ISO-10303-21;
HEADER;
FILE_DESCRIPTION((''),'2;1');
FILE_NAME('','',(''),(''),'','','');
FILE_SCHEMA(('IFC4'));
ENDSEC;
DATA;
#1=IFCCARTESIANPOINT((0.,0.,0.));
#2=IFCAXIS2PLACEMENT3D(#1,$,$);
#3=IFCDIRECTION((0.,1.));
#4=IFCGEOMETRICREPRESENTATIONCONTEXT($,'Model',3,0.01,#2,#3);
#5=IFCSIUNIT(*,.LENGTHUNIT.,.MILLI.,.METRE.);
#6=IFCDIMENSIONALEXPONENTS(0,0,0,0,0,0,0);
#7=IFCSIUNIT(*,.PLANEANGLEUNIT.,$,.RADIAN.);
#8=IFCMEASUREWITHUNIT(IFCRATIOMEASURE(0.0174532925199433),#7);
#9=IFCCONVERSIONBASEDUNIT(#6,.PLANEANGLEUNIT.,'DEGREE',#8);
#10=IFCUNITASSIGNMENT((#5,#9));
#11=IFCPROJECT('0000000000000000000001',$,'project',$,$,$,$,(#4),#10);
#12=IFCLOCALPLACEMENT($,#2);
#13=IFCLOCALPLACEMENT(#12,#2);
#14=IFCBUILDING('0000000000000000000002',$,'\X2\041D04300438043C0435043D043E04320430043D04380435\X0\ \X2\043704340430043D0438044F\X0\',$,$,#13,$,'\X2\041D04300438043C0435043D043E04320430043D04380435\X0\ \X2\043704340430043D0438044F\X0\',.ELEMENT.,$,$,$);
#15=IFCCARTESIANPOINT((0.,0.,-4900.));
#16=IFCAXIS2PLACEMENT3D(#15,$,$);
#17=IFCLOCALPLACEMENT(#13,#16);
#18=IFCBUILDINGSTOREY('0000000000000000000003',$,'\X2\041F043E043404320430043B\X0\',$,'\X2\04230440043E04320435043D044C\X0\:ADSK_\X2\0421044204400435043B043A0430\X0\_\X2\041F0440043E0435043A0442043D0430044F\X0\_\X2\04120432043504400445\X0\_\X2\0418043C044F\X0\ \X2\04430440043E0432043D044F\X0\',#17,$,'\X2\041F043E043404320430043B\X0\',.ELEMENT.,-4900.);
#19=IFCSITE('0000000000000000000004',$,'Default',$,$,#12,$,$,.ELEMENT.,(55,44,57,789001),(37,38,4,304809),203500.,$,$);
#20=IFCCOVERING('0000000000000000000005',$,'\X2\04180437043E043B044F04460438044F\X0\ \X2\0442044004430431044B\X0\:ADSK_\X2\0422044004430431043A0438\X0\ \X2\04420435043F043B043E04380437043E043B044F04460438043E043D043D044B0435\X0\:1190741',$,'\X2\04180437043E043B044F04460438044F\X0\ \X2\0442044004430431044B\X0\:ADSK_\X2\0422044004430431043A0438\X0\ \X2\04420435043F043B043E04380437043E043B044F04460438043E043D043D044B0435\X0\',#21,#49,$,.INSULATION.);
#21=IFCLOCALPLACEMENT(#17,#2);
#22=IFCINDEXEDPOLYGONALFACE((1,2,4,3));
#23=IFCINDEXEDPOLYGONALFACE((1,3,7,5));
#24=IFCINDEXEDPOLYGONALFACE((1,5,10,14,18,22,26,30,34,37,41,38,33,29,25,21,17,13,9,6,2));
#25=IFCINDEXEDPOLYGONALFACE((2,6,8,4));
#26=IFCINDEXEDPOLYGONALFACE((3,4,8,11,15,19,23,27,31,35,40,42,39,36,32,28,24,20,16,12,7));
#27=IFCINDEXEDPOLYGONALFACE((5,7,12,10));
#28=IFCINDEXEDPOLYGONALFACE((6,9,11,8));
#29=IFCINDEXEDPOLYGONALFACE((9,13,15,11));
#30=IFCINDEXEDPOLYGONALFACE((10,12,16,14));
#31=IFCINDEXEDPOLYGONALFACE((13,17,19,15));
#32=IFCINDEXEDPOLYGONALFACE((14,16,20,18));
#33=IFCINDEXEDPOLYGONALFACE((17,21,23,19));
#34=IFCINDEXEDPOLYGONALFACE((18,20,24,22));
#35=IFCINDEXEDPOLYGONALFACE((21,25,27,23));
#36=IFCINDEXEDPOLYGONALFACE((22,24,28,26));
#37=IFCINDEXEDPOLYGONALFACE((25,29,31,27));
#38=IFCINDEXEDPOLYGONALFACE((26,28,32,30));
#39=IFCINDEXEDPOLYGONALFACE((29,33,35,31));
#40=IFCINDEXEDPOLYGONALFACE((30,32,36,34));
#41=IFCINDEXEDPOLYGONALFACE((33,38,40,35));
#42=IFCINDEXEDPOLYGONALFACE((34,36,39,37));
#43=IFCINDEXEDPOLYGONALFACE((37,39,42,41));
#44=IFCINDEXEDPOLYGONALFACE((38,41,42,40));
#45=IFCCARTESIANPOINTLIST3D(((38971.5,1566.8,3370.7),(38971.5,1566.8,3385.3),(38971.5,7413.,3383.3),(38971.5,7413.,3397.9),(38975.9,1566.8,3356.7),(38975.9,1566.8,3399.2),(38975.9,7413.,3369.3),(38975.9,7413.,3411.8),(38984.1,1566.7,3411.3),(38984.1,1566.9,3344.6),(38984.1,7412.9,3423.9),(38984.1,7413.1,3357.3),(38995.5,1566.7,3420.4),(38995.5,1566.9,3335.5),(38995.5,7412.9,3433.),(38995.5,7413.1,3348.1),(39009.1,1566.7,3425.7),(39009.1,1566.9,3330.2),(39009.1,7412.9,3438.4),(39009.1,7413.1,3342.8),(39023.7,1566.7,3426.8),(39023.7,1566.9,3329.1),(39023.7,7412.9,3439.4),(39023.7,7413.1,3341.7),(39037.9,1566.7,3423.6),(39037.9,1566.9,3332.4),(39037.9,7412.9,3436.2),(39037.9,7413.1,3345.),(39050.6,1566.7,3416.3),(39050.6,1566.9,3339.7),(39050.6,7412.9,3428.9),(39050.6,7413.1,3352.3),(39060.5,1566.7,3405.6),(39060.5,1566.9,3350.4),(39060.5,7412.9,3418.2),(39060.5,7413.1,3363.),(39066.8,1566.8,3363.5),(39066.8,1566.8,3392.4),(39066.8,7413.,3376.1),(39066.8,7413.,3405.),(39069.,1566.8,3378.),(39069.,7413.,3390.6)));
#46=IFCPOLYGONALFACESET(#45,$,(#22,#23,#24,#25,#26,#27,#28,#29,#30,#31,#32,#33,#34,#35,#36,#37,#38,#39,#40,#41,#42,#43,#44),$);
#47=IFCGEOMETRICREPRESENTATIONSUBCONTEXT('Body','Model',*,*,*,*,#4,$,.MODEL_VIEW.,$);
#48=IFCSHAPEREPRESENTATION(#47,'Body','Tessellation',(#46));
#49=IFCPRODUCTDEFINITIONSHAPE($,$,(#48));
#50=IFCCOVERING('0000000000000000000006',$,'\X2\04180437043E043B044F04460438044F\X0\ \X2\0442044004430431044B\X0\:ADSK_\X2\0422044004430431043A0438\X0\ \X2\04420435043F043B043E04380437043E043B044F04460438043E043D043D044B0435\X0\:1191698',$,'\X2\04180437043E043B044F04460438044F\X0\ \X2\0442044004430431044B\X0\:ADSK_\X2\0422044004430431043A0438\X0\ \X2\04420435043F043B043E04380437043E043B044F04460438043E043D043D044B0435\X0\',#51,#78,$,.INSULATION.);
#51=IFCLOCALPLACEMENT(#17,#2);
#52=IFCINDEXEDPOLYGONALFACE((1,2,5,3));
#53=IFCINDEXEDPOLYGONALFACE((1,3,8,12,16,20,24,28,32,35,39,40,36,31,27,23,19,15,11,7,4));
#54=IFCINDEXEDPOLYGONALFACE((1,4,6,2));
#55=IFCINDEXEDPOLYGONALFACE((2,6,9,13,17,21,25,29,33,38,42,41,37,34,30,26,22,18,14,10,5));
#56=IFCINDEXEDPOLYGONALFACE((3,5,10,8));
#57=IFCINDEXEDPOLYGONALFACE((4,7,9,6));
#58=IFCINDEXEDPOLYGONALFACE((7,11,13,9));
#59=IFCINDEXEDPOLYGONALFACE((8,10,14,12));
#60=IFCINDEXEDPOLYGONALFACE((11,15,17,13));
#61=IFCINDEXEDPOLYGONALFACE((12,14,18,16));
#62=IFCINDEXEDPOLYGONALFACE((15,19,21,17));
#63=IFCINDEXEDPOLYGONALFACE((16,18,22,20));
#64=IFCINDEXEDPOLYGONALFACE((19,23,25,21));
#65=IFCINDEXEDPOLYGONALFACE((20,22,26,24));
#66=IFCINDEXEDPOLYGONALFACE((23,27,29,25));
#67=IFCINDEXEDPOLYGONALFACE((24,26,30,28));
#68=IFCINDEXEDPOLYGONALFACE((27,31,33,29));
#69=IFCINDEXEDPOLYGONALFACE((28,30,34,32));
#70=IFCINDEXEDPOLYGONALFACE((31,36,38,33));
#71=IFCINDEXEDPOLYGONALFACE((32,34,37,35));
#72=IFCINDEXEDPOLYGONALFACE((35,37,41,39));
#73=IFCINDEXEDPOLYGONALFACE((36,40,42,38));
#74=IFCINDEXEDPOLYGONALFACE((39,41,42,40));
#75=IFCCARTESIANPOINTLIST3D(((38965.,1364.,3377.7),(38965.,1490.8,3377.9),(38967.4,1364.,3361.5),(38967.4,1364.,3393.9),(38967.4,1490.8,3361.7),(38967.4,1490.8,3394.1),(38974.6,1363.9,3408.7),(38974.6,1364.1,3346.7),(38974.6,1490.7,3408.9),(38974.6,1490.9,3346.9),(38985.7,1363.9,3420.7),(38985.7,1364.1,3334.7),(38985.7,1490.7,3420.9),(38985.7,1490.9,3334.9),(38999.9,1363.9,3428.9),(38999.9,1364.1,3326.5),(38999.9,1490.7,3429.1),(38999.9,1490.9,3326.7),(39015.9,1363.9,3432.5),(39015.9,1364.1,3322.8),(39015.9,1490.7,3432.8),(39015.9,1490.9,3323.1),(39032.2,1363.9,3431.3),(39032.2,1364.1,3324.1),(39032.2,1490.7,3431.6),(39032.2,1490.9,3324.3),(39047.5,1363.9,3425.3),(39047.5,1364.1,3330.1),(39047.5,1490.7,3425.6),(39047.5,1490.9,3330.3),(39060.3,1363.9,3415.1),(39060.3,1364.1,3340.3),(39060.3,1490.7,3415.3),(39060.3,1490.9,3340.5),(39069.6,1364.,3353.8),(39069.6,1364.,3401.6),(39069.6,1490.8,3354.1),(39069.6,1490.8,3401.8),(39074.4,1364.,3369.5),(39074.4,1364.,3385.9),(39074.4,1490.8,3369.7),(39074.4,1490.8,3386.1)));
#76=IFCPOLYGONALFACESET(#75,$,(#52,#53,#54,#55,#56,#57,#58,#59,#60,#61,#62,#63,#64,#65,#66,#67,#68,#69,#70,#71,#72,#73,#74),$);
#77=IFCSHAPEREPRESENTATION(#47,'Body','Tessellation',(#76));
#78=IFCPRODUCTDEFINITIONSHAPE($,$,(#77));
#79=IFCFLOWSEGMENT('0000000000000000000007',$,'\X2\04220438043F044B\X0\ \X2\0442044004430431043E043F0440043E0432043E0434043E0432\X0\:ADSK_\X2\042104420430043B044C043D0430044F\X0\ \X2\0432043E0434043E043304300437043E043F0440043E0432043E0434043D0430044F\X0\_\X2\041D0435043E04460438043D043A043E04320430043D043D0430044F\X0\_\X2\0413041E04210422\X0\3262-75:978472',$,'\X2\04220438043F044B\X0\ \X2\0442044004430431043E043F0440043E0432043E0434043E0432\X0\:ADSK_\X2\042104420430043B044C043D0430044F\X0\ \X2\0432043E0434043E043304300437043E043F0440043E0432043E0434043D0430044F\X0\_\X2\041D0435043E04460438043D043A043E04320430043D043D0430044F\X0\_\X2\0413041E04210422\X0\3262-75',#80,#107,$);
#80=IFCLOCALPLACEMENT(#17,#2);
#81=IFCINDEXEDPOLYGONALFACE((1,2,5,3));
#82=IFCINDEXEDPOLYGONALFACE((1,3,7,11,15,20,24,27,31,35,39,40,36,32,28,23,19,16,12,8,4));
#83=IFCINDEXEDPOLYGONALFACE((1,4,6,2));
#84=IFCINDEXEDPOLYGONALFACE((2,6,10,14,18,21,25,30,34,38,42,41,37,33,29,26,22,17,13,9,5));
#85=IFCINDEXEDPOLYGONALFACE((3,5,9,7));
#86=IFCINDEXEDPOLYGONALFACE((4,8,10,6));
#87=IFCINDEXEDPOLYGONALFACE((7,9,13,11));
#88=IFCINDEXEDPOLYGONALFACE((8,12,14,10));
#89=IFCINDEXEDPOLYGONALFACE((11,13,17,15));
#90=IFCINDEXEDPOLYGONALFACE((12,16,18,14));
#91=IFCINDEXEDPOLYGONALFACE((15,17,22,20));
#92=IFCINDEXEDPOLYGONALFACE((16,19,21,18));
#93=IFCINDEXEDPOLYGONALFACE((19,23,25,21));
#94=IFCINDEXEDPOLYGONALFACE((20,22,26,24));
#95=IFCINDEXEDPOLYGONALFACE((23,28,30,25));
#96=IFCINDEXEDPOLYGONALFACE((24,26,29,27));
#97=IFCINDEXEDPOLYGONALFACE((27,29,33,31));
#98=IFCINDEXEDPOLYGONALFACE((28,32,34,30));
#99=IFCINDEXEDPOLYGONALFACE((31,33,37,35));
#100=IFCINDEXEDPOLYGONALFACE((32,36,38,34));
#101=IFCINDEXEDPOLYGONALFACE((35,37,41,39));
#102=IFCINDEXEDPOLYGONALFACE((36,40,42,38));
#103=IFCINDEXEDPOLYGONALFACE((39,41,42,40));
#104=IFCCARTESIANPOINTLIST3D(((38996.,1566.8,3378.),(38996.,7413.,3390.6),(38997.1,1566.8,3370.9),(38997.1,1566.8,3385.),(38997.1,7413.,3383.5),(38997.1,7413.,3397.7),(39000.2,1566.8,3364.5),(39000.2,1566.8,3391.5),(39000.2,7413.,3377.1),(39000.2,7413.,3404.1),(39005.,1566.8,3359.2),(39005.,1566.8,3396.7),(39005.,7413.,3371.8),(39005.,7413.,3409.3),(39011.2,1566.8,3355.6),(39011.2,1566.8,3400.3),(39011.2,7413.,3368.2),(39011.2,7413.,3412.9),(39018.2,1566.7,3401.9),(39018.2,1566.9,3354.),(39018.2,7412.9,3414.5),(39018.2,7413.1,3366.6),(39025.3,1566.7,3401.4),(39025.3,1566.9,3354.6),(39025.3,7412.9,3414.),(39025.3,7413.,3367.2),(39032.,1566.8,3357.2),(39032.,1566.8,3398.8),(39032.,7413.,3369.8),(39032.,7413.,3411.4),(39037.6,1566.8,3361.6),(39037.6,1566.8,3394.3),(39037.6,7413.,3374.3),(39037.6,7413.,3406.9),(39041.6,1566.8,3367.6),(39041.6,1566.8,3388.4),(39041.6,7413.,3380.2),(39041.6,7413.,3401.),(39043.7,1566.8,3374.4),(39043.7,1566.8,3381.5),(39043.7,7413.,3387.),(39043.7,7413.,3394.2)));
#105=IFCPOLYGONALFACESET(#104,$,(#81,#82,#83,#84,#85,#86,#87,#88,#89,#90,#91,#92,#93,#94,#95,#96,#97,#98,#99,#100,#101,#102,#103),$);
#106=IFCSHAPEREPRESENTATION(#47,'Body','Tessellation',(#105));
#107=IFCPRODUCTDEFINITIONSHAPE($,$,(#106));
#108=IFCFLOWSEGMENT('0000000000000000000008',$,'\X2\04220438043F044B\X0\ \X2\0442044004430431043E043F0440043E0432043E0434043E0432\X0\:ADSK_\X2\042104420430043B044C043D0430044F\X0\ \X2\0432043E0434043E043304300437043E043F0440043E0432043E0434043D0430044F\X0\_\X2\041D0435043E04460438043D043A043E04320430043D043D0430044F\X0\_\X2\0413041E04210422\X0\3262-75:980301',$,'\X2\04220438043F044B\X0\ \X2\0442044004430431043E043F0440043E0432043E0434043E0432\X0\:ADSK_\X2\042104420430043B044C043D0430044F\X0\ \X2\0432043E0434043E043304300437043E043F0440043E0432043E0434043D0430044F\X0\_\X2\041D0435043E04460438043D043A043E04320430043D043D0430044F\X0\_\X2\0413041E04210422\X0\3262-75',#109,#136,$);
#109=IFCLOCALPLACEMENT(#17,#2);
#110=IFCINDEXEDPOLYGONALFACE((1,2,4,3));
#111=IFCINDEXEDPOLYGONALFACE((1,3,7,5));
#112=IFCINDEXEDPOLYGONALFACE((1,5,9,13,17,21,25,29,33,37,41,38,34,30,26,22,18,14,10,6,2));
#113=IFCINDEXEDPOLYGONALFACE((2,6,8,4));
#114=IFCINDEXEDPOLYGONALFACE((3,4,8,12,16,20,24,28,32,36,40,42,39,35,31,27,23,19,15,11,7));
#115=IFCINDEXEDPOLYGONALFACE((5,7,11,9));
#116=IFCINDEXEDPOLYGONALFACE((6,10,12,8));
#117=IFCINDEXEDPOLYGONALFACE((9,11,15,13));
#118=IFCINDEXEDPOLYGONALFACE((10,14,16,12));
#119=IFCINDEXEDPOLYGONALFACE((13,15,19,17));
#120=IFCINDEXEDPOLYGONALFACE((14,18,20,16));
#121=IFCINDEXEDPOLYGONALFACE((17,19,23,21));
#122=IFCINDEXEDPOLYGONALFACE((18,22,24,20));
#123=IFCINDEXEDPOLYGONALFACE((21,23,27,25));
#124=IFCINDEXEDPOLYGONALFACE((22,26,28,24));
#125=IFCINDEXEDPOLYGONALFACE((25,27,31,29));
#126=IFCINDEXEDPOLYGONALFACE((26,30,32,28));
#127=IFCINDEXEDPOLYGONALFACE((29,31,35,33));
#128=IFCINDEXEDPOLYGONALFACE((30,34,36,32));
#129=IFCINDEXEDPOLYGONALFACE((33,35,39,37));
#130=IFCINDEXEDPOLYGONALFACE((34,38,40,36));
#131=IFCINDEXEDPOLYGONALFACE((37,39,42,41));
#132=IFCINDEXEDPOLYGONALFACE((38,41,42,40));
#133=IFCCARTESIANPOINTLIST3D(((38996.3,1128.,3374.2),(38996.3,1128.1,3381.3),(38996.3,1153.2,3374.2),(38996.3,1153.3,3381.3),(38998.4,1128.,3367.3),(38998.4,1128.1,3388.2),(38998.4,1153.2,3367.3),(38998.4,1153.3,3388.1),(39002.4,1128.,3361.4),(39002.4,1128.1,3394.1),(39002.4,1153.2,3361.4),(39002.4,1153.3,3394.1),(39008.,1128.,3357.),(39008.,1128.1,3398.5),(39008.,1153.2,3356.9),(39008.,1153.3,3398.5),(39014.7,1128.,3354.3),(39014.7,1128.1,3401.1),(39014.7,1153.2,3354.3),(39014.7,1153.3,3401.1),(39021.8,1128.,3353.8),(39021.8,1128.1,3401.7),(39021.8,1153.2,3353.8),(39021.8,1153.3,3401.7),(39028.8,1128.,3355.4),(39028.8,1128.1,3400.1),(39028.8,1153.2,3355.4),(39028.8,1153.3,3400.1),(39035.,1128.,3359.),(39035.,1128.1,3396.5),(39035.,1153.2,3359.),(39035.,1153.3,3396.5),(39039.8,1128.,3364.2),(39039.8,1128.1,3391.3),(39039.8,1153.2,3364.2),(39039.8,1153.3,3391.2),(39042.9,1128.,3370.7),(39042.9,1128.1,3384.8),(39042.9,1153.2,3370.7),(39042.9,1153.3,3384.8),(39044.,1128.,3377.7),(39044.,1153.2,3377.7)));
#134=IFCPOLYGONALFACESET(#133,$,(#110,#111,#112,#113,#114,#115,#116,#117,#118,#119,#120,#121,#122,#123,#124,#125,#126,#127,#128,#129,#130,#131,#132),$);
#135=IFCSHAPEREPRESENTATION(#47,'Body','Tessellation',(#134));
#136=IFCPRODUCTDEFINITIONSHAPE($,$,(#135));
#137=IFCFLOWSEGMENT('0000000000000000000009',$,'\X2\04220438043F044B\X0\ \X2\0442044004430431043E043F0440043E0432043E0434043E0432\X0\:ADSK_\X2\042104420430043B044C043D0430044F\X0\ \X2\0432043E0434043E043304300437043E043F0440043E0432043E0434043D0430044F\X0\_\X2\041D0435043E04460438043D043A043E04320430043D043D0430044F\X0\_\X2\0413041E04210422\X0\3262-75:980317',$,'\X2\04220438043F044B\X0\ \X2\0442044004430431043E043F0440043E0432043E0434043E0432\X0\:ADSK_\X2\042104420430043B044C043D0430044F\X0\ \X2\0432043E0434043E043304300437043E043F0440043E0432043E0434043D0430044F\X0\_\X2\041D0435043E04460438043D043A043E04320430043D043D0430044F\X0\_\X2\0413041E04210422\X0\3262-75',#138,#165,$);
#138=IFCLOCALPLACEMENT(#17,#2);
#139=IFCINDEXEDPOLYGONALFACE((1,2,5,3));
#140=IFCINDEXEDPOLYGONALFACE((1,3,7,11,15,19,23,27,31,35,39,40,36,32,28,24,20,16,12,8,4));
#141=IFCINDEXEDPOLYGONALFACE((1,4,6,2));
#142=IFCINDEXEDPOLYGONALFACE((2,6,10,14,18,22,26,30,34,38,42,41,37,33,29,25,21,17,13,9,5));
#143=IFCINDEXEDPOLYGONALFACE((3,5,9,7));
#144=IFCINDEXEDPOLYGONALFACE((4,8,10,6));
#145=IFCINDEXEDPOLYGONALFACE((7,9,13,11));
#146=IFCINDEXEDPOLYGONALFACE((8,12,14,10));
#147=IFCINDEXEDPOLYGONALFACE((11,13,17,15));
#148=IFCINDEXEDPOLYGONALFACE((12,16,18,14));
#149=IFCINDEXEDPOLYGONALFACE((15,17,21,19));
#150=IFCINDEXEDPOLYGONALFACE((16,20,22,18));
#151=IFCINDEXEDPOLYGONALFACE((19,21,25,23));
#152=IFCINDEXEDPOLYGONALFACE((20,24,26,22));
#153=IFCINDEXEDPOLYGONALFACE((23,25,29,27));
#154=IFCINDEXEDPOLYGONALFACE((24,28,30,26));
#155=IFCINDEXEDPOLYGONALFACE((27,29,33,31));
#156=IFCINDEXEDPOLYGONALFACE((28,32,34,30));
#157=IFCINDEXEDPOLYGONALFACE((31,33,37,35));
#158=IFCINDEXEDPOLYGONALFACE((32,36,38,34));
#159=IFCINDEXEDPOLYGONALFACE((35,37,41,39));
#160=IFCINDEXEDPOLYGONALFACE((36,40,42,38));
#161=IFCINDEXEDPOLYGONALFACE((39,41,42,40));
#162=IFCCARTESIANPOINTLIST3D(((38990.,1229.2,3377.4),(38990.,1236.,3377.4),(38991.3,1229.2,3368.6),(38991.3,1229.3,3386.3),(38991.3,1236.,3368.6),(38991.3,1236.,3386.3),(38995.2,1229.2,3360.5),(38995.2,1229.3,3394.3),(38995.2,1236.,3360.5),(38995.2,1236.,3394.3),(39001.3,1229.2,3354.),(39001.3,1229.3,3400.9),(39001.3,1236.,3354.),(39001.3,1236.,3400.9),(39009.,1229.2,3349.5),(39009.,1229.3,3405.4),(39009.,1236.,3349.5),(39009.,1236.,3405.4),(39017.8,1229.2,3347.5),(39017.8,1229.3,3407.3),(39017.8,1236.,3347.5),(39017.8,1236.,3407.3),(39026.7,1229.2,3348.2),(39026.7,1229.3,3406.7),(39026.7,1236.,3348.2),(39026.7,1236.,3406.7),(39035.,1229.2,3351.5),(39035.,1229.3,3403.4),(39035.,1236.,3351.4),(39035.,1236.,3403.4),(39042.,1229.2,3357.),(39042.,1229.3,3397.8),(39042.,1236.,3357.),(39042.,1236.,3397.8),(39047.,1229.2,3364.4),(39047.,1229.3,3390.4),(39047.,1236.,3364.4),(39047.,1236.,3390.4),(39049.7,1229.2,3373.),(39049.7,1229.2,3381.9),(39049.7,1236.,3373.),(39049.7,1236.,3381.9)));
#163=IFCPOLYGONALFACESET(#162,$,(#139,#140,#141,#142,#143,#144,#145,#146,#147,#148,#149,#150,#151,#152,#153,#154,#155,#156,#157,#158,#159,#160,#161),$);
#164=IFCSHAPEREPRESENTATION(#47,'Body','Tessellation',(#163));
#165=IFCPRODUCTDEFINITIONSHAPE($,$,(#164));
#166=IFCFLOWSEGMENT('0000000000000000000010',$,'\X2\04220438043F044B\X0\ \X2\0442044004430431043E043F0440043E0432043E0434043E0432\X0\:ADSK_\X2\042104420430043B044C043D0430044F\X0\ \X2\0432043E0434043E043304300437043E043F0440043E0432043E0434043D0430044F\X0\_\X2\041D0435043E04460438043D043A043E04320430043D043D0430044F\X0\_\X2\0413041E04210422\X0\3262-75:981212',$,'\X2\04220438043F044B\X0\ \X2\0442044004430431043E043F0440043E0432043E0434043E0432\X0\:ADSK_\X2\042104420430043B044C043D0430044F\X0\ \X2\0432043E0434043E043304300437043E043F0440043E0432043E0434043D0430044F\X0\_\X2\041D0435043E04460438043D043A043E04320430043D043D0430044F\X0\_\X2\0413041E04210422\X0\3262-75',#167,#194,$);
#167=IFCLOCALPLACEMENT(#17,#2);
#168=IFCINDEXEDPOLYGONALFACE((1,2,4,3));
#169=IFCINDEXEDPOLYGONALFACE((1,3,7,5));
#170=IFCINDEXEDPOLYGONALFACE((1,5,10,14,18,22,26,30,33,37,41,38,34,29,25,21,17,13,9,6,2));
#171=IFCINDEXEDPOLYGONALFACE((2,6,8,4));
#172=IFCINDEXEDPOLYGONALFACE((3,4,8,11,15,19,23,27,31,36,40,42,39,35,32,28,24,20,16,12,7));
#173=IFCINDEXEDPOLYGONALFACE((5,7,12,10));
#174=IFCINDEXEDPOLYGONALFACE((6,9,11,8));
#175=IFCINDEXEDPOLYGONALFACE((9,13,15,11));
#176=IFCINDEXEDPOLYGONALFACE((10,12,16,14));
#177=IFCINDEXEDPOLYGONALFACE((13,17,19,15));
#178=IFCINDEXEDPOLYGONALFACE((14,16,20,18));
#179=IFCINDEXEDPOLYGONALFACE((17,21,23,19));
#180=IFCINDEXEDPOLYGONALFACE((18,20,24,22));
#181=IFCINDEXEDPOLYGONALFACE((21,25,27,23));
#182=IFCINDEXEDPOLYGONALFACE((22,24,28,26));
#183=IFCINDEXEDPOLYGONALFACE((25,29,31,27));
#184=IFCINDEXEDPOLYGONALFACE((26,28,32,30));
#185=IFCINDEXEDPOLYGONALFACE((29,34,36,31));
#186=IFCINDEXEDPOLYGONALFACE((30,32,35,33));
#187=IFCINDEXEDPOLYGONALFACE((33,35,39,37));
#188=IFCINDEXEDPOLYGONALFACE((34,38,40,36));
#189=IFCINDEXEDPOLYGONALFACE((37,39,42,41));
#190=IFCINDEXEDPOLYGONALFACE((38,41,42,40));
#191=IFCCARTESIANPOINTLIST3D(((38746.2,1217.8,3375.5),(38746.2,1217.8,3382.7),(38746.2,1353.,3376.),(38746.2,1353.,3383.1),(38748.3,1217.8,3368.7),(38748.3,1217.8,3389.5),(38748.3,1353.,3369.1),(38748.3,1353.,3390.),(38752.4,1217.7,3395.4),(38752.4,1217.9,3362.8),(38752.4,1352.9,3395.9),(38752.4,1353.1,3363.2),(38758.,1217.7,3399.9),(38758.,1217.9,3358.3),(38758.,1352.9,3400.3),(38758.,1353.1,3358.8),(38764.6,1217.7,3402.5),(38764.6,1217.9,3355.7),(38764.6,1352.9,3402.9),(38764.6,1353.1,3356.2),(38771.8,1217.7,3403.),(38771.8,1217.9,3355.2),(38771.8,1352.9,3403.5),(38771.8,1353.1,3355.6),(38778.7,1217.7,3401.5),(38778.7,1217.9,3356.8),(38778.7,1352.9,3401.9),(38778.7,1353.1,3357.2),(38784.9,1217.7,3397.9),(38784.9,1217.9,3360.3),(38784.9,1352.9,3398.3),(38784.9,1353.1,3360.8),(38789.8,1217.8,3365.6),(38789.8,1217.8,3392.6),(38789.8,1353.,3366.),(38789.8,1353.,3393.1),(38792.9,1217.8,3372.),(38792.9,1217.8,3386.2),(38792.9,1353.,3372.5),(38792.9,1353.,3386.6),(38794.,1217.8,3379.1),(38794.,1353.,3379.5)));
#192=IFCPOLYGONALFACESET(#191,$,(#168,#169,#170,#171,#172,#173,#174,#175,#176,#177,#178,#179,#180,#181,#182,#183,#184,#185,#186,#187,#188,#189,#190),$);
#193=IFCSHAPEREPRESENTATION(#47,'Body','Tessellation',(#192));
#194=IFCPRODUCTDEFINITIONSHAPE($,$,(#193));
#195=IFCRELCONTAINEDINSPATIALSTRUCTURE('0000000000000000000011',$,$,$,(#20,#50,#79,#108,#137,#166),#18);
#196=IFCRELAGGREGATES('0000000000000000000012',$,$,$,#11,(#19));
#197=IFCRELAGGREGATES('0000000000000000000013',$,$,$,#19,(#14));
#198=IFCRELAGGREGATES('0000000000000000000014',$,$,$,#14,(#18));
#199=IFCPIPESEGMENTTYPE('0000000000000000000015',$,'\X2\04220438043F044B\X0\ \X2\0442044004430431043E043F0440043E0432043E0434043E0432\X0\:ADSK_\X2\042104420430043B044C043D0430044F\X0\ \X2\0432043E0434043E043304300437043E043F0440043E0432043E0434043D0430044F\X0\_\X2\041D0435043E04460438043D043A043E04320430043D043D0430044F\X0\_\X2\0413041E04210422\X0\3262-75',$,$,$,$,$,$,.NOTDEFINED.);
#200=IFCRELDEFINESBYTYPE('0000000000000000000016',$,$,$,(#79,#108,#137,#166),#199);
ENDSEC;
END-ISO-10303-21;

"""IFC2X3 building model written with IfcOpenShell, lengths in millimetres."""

from ifc_helpers import new_model, entity, si_unit, converted_unit, direction, frame, origin, origin_2d_with_axis, place, context, subcontext, project, spatial, circle, extrude, type_object, element, save


model = new_model("IFC2X3")

# Units and contexts
model_context = context("Model", 3, precision=0.01, world=origin(), true_north=direction((0.0, 1.0)))
body_context = subcontext(model_context, "Body", "Model", "MODEL_VIEW")
ifc_project = project(units=[si_unit("LENGTHUNIT", "METRE", prefix="MILLI"), converted_unit("PLANEANGLEUNIT", "DEGREE", entity("IfcRatioMeasure", 0.0174532925199433), si_unit("PLANEANGLEUNIT", "RADIAN"), dimensions=[0, 0, 0, 0, 0, 0, 0])], contexts=[model_context])

# Site, building, storey
site_placement = place(None, origin())
site = spatial("IfcSite", under=ifc_project, at=site_placement, Name="Default", CompositionType="ELEMENT", RefLatitude=(55, 44, 57, 789001), RefLongitude=(37, 38, 4, 304809), RefElevation=203500.0)
building_placement = place(site_placement, origin())
building = spatial("IfcBuilding", under=site, at=building_placement, Name="Наименование здания", LongName="Наименование здания", CompositionType="ELEMENT")
storey_placement = place(building_placement, frame((0.0, 0.0, -4900.0)))
storey = spatial("IfcBuildingStorey", under=building, at=storey_placement, Name="Подвал", ObjectType="Уровень:ADSK_Стрелка_Проектная_Вверх_Имя уровня", LongName="Подвал", CompositionType="ELEMENT", Elevation=-4900.0)

# Coverings
covering_1_placement = place(storey_placement, frame((38969.4, 1566.7, 3327.4)))
element("IfcCovering", 1, at=covering_1_placement, inside=storey, Name="Изоляция трубы:ADSK_Трубки теплоизоляционные:1190741", ObjectType="Изоляция трубы:ADSK_Трубки теплоизоляционные", PredefinedType="INSULATION", context=body_context, shape_type="SweptSolid", body=[
    extrude(circle(Radius=49.0, at=origin_2d_with_axis()), frame((50.6, 0.1, 50.6), z_axis=(0.0, 0.999998, 0.002157), x_axis=(1.0, 0.0, 0.0)), (0.0, 0.0, 1.0), 5846.2),
])
covering_2_placement = place(storey_placement, frame((38963.4, 1363.9, 3321.1)))
element("IfcCovering", 2, at=covering_2_placement, inside=storey, Name="Изоляция трубы:ADSK_Трубки теплоизоляционные:1191698", ObjectType="Изоляция трубы:ADSK_Трубки теплоизоляционные", PredefinedType="INSULATION", context=body_context, shape_type="SweptSolid", body=[
    extrude(circle(Radius=55.0, at=origin_2d_with_axis()), frame((56.6, 0.1, 56.6), z_axis=(0.0, 0.999998, 0.001906), x_axis=(-1.0, 0.0, 0.0)), (0.0, 0.0, 1.0), 126.8),
])

# Flow segments
pipe_segment_type = type_object("IfcPipeSegmentType", Name="Типы трубопроводов:ADSK_Стальная водогазопроводная_Неоцинкованная_ГОСТ3262-75", PredefinedType="NOTDEFINED")
flow_segment_1_placement = place(storey_placement, frame((38994.4, 1566.8, 3352.4)))
element("IfcFlowSegment", 3, at=flow_segment_1_placement, inside=storey, type_object=pipe_segment_type, Name="Типы трубопроводов:ADSK_Стальная водогазопроводная_Неоцинкованная_ГОСТ3262-75:978472", ObjectType="Типы трубопроводов:ADSK_Стальная водогазопроводная_Неоцинкованная_ГОСТ3262-75", context=body_context, shape_type="SweptSolid", body=[
    extrude(circle(Radius=24.0, at=origin_2d_with_axis()), frame((25.6, 0.1, 25.6), z_axis=(0.0, 0.999998, 0.002157), x_axis=(-1.0, 0.0, 0.0)), (0.0, 0.0, 1.0), 5846.2),
])
flow_segment_2_placement = place(storey_placement, frame((38994.4, 1128.0, 3352.1)))
element("IfcFlowSegment", 4, at=flow_segment_2_placement, inside=storey, type_object=pipe_segment_type, Name="Типы трубопроводов:ADSK_Стальная водогазопроводная_Неоцинкованная_ГОСТ3262-75:980301", ObjectType="Типы трубопроводов:ADSK_Стальная водогазопроводная_Неоцинкованная_ГОСТ3262-75", context=body_context, shape_type="SweptSolid", body=[
    extrude(circle(Radius=24.0, at=origin_2d_with_axis()), frame((25.6, 0.0, 25.6), z_axis=(0.0, 1.0, -0.000479), x_axis=(1.0, 0.0, 0.0)), (0.0, 0.0, 1.0), 25.2),
])
flow_segment_3_placement = place(storey_placement, frame((38988.4, 1229.2, 3345.8)))
element("IfcFlowSegment", 5, at=flow_segment_3_placement, inside=storey, type_object=pipe_segment_type, Name="Типы трубопроводов:ADSK_Стальная водогазопроводная_Неоцинкованная_ГОСТ3262-75:980317", ObjectType="Типы трубопроводов:ADSK_Стальная водогазопроводная_Неоцинкованная_ГОСТ3262-75", context=body_context, shape_type="SweptSolid", body=[
    extrude(circle(Radius=30.0, at=origin_2d_with_axis()), frame((31.6, 6.8, 31.6), z_axis=(0.0, -1.0, 0.000479), x_axis=(-1.0, 0.0, 0.0)), (0.0, 0.0, 1.0), 6.8),
])
flow_segment_4_placement = place(storey_placement, frame((38744.4, 1217.7, 3353.5)))
element("IfcFlowSegment", 6, at=flow_segment_4_placement, inside=storey, type_object=pipe_segment_type, Name="Типы трубопроводов:ADSK_Стальная водогазопроводная_Неоцинкованная_ГОСТ3262-75:981212", ObjectType="Типы трубопроводов:ADSK_Стальная водогазопроводная_Неоцинкованная_ГОСТ3262-75", context=body_context, shape_type="SweptSolid", body=[
    extrude(circle(Radius=24.0, at=origin_2d_with_axis()), frame((25.6, 0.1, 25.6), z_axis=(0.0, 0.999995, 0.003245), x_axis=(1.0, 0.0, 0.0)), (0.0, 0.0, 1.0), 135.2),
])

save(model, "model.ifc")
